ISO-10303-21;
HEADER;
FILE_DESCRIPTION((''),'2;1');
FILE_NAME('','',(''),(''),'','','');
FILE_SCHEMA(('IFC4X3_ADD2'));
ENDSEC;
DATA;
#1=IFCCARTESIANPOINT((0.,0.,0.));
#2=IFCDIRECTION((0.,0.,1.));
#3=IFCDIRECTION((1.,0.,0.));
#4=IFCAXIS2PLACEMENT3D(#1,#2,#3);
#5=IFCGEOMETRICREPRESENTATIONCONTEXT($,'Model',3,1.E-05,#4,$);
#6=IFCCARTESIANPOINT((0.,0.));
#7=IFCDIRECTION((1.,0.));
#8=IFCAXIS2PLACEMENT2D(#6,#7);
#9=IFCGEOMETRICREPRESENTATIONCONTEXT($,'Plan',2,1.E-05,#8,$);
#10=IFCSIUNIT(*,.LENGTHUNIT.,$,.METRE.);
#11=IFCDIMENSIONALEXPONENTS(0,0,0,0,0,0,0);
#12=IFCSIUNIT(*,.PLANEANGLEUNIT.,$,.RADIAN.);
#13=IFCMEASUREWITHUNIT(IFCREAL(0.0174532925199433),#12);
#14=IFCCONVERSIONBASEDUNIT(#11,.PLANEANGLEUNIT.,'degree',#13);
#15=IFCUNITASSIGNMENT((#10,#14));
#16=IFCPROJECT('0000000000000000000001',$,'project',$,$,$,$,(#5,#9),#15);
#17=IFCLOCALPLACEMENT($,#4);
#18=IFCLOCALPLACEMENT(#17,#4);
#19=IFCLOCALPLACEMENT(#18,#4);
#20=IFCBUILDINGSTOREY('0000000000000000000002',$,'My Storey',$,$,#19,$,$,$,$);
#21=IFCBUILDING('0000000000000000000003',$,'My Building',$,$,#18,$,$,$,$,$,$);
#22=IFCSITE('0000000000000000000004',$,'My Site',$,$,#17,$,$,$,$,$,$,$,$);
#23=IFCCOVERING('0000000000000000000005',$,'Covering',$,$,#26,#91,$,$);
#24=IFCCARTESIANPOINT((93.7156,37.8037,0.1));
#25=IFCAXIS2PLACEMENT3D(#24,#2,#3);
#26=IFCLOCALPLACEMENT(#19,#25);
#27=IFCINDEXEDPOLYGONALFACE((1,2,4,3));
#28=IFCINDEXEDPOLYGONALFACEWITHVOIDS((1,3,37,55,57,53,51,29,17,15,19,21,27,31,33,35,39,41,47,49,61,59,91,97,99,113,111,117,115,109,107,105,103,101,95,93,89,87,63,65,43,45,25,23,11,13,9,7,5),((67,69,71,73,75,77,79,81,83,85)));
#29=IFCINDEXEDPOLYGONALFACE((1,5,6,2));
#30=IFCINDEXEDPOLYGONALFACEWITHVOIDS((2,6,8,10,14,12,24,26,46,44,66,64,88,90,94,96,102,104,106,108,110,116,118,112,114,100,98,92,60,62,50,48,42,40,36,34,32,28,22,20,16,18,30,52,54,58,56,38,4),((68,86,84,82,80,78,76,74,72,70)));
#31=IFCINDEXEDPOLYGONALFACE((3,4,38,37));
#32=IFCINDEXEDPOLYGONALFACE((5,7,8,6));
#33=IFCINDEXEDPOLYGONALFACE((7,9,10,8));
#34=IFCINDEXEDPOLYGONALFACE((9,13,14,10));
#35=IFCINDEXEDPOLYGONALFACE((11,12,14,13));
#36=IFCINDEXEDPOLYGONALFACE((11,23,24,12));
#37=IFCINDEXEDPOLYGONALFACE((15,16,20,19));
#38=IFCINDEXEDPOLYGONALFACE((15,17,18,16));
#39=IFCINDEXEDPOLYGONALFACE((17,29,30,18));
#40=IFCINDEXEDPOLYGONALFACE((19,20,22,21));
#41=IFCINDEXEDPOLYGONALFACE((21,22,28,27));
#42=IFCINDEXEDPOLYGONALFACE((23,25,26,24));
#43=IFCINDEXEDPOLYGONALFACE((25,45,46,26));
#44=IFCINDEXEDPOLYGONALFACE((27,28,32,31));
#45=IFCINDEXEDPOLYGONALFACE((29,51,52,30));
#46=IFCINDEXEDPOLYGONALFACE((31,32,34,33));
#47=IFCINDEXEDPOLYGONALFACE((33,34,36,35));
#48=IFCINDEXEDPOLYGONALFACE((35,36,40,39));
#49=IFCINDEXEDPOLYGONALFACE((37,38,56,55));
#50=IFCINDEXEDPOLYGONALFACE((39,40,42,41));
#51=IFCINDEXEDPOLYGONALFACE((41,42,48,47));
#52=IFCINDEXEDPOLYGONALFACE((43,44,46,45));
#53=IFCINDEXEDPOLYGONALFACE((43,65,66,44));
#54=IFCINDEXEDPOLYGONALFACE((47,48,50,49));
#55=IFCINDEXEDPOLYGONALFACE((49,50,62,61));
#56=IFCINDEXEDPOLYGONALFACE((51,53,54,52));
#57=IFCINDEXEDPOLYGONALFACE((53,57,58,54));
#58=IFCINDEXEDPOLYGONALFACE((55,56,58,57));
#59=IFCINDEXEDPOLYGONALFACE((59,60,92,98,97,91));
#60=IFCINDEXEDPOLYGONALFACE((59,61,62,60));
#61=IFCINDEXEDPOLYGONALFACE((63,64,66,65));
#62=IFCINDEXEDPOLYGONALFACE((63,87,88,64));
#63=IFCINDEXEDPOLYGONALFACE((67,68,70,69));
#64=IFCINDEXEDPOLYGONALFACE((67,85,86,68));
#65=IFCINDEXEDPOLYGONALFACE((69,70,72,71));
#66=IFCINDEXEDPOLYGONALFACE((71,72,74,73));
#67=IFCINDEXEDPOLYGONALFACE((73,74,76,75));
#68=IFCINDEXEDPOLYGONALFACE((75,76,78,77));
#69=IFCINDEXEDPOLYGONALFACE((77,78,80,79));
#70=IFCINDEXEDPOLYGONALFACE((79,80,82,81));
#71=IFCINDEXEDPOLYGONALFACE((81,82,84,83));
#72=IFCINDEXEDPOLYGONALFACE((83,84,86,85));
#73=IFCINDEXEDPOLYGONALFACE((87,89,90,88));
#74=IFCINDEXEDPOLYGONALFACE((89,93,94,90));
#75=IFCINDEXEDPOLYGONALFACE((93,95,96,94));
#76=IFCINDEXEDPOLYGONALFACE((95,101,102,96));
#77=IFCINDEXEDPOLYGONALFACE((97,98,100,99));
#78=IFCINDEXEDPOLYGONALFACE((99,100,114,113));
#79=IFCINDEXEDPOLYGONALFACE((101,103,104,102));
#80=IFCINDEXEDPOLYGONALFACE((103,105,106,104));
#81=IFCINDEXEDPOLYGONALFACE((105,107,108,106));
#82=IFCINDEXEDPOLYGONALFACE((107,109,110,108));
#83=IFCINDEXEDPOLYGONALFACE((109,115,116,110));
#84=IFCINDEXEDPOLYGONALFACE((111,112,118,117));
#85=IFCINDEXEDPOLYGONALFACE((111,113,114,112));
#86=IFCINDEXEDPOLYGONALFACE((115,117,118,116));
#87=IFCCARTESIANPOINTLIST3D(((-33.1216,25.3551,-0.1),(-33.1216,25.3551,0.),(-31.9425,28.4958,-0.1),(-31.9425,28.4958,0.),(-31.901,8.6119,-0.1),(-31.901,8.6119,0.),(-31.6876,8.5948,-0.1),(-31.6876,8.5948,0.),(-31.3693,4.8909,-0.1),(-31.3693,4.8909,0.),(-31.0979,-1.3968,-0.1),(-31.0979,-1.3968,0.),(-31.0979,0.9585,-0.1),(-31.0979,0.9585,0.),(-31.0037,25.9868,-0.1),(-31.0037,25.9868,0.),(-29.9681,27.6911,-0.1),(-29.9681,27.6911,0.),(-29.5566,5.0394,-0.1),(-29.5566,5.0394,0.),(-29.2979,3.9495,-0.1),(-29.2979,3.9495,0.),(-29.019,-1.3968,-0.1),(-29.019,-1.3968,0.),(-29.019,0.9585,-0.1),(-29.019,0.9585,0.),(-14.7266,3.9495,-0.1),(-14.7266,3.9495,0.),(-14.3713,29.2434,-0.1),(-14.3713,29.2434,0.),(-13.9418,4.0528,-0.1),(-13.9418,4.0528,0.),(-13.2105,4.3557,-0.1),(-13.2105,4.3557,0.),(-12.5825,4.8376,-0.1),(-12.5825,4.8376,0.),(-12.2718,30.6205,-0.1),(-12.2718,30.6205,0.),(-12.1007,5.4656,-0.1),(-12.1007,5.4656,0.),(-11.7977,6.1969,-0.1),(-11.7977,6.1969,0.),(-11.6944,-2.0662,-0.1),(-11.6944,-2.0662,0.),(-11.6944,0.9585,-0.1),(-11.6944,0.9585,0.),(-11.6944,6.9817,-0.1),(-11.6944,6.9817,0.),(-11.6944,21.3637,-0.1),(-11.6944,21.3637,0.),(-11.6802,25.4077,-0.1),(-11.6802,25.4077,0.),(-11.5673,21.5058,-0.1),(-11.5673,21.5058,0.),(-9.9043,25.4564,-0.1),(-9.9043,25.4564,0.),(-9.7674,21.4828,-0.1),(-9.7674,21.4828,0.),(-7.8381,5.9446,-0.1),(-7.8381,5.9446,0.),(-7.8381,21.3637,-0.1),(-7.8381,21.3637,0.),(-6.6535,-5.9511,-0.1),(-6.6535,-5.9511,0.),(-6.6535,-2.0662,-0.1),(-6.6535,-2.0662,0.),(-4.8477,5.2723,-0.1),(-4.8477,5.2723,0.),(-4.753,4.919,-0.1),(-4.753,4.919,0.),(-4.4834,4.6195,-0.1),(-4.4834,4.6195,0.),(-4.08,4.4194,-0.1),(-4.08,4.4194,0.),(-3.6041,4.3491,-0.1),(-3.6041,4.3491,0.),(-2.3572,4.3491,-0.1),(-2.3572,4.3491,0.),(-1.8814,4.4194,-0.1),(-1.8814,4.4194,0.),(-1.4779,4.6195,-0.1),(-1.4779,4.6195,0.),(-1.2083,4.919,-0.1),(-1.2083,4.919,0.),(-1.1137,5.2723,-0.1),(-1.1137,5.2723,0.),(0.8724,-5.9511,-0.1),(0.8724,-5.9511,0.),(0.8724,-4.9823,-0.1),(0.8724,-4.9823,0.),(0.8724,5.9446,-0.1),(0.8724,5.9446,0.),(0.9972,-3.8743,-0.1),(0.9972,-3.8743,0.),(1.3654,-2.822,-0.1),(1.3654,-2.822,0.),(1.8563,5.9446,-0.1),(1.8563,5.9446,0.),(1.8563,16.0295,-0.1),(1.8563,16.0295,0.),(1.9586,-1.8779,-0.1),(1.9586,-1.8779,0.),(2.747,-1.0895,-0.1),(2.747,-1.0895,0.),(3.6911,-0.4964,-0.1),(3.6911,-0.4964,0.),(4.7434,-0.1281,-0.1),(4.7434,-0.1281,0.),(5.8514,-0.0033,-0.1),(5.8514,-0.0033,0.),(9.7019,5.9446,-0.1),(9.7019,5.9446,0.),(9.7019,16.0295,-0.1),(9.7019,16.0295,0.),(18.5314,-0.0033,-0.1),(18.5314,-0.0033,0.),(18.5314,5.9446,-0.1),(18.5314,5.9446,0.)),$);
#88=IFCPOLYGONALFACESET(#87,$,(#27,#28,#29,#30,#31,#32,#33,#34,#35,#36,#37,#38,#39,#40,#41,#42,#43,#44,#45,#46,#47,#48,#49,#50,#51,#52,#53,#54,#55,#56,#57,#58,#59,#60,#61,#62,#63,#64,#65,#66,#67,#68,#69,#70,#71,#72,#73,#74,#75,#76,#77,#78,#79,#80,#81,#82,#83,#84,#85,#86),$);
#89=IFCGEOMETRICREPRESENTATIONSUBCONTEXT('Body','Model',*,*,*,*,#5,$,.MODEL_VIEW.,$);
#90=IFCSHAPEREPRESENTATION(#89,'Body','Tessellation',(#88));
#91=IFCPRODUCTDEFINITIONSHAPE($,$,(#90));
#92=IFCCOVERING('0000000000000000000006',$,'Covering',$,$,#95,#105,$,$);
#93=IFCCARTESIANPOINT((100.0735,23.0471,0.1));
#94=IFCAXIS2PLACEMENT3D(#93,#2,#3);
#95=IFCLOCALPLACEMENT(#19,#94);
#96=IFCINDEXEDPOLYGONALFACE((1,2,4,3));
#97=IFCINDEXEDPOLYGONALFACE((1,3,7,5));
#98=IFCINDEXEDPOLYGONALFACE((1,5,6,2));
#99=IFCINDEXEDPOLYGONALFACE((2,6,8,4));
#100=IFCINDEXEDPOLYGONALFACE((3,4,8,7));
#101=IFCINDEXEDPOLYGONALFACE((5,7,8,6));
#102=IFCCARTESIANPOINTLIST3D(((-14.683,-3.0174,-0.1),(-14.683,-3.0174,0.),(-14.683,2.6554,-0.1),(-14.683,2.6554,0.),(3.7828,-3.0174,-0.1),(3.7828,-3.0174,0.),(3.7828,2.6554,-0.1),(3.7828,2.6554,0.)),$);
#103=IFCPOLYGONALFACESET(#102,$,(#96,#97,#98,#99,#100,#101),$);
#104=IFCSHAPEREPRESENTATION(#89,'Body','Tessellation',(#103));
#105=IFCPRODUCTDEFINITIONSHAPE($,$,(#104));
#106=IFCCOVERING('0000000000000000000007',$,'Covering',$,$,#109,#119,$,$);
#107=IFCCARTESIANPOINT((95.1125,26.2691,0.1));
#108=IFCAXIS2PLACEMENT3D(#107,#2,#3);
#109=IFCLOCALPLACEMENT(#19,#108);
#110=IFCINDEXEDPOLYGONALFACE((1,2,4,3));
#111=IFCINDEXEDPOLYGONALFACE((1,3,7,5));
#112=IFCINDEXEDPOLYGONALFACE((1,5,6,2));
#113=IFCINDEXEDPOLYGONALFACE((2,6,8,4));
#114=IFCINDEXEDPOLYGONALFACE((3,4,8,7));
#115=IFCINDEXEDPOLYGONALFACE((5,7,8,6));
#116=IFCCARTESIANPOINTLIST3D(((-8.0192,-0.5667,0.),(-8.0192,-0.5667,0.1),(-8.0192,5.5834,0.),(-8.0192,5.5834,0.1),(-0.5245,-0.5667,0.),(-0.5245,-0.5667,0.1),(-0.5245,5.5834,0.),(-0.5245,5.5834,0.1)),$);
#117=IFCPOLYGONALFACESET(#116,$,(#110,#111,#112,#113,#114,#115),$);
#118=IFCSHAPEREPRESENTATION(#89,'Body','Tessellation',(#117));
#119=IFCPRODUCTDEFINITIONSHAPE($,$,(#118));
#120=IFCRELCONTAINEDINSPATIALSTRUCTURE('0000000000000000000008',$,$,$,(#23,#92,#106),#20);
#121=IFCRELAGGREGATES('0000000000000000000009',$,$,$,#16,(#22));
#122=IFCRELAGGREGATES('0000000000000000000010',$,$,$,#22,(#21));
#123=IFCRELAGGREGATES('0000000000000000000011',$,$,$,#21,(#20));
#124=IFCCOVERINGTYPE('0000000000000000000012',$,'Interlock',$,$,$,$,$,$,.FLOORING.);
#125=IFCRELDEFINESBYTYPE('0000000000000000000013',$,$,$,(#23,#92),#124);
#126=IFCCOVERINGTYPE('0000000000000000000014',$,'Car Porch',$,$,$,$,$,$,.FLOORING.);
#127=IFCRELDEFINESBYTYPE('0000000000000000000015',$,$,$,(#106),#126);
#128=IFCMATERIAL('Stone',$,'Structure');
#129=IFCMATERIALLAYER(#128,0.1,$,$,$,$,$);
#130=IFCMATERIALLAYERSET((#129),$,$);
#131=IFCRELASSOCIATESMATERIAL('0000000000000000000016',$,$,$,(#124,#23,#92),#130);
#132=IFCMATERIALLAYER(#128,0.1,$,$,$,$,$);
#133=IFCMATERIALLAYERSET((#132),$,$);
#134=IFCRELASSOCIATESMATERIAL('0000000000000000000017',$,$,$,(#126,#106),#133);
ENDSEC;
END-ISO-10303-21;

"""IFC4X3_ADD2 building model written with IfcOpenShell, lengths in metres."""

from ifc_helpers import new_model, entity, si_unit, converted_unit, frame, origin_with_axes, origin_2d_with_axis, place, context, subcontext, project, spatial, indexed_curve, outline, extrude, material, layer, layer_set, layer_usage, type_object, element, save


model = new_model("IFC4X3_ADD2")

# Units and contexts
model_context = context("Model", 3, precision=1e-05, world=origin_with_axes())
plan_context = context("Plan", 2, precision=1e-05, world=origin_2d_with_axis())
body_context = subcontext(model_context, "Body", "Model", "MODEL_VIEW")
ifc_project = project(units=[si_unit("LENGTHUNIT", "METRE"), converted_unit("PLANEANGLEUNIT", "degree", entity("IfcReal", 0.0174532925199433), si_unit("PLANEANGLEUNIT", "RADIAN"), dimensions=[0, 0, 0, 0, 0, 0, 0])], contexts=[model_context, plan_context])

# Site, building, storey
site_placement = place(None, origin_with_axes())
site = spatial("IfcSite", under=ifc_project, at=site_placement, Name="My Site")
building_placement = place(site_placement, origin_with_axes())
building = spatial("IfcBuilding", under=site, at=building_placement, Name="My Building")
storey_placement = place(building_placement, origin_with_axes())
storey = spatial("IfcBuildingStorey", under=building, at=storey_placement, Name="My Storey")

# Coverings
ifc_material = material(Name="Stone", Category="Structure")
ifc_layer_1 = layer(ifc_material, 0.1)
ifc_layer_set_1 = layer_set([ifc_layer_1])
ifc_layer_usage_1 = layer_usage(ifc_layer_set_1, "AXIS3", "POSITIVE", -0.1)
covering_type_1 = type_object("IfcCoveringType", Name="Interlock", PredefinedType="FLOORING", material=ifc_layer_set_1)
covering_1_placement = place(storey_placement, frame((93.7156, 37.8037, 0.1), z_axis=(0.0, 0.0, 1.0), x_axis=(1.0, 0.0, 0.0)))
element("IfcCovering", 1, at=covering_1_placement, inside=storey, type_object=covering_type_1, material=ifc_layer_usage_1, Name="Covering", context=body_context, shape_type="SweptSolid", body=[
    extrude(outline(indexed_curve([(-31.0979, 0.9585), (-31.3693, 4.8909), (-31.6876, 8.5948), (-31.901, 8.6119), (-33.1216, 25.3551), (-31.9425, 28.4958), (-12.2718, 30.6205), (-9.9043, 25.4564), (-9.7674, 21.4828), (-11.5673, 21.5058), (-11.6802, 25.4077), (-14.3713, 29.2434), (-29.9681, 27.6911), (-31.0037, 25.9868), (-29.5566, 5.0394), (-29.2979, 3.9495), (-14.7266, 3.9495), (-13.9418, 4.0528), (-13.2105, 4.3557), (-12.5825, 4.8376), (-12.1007, 5.4656), (-11.7977, 6.1969), (-11.6944, 6.9817), (-11.6944, 21.3637), (-7.8381, 21.3637), (-7.8381, 5.9446), (0.8724, 5.9446), (1.8563, 5.9446), (1.8563, 16.0295), (9.7019, 16.0295), (9.7019, 5.9446), (18.5314, 5.9446), (18.5314, -0.0033), (5.8514, -0.0033), (4.7434, -0.1281), (3.6911, -0.4964), (2.747, -1.0895), (1.9586, -1.8779), (1.3654, -2.822), (0.9972, -3.8743), (0.8724, -4.9823), (0.8724, -5.9511), (-6.6535, -5.9511), (-6.6535, -2.0662), (-11.6944, -2.0662), (-11.6944, 0.9585), (-29.019, 0.9585), (-29.019, -1.3968), (-31.0979, -1.3968), (-31.0979, 0.9585)]), holes=[indexed_curve([(-4.753, 4.919), (-4.4834, 4.6195), (-4.08, 4.4194), (-3.6041, 4.3491), (-2.3572, 4.3491), (-1.8814, 4.4194), (-1.4779, 4.6195), (-1.2083, 4.919), (-1.1137, 5.2723), (-4.8477, 5.2723), (-4.753, 4.919)])]), frame((0.0, 0.0, -0.1), z_axis=(0.0, 0.0, 1.0), x_axis=(1.0, 0.0, 0.0)), (0.0, 0.0, 1.0), 0.1),
])
ifc_layer_usage_2 = layer_usage(ifc_layer_set_1, "AXIS3", "POSITIVE", -0.1)
covering_2_placement = place(storey_placement, frame((100.0735, 23.0471, 0.1), z_axis=(0.0, 0.0, 1.0), x_axis=(1.0, 0.0, 0.0)))
element("IfcCovering", 2, at=covering_2_placement, inside=storey, type_object=covering_type_1, material=ifc_layer_usage_2, Name="Covering", context=body_context, shape_type="SweptSolid", body=[
    extrude(outline(indexed_curve([(3.7828, -3.0174), (3.7828, 2.6554), (-14.683, 2.6554), (-14.683, -3.0174), (3.7828, -3.0174)])), frame((0.0, 0.0, -0.1), z_axis=(0.0, 0.0, 1.0), x_axis=(1.0, 0.0, 0.0)), (0.0, 0.0, 1.0), 0.1),
])
ifc_layer_2 = layer(ifc_material, 0.1)
ifc_layer_set_2 = layer_set([ifc_layer_2])
ifc_layer_usage_3 = layer_usage(ifc_layer_set_2, "AXIS3", "POSITIVE", 0.0)
covering_type_2 = type_object("IfcCoveringType", Name="Car Porch", PredefinedType="FLOORING", material=ifc_layer_set_2)
covering_3_placement = place(storey_placement, frame((95.1125, 26.2691, 0.1), z_axis=(0.0, 0.0, 1.0), x_axis=(1.0, 0.0, 0.0)))
element("IfcCovering", 3, at=covering_3_placement, inside=storey, type_object=covering_type_2, material=ifc_layer_usage_3, Name="Covering", context=body_context, shape_type="SweptSolid", body=[
    extrude(outline(indexed_curve([(-0.5245, 5.5834), (-8.0192, 5.5834), (-8.0192, -0.5667), (-0.5245, -0.5667), (-0.5245, 5.5834)])), None, (0.0, 0.0, 1.0), 0.1),
])

save(model, "model.ifc")
